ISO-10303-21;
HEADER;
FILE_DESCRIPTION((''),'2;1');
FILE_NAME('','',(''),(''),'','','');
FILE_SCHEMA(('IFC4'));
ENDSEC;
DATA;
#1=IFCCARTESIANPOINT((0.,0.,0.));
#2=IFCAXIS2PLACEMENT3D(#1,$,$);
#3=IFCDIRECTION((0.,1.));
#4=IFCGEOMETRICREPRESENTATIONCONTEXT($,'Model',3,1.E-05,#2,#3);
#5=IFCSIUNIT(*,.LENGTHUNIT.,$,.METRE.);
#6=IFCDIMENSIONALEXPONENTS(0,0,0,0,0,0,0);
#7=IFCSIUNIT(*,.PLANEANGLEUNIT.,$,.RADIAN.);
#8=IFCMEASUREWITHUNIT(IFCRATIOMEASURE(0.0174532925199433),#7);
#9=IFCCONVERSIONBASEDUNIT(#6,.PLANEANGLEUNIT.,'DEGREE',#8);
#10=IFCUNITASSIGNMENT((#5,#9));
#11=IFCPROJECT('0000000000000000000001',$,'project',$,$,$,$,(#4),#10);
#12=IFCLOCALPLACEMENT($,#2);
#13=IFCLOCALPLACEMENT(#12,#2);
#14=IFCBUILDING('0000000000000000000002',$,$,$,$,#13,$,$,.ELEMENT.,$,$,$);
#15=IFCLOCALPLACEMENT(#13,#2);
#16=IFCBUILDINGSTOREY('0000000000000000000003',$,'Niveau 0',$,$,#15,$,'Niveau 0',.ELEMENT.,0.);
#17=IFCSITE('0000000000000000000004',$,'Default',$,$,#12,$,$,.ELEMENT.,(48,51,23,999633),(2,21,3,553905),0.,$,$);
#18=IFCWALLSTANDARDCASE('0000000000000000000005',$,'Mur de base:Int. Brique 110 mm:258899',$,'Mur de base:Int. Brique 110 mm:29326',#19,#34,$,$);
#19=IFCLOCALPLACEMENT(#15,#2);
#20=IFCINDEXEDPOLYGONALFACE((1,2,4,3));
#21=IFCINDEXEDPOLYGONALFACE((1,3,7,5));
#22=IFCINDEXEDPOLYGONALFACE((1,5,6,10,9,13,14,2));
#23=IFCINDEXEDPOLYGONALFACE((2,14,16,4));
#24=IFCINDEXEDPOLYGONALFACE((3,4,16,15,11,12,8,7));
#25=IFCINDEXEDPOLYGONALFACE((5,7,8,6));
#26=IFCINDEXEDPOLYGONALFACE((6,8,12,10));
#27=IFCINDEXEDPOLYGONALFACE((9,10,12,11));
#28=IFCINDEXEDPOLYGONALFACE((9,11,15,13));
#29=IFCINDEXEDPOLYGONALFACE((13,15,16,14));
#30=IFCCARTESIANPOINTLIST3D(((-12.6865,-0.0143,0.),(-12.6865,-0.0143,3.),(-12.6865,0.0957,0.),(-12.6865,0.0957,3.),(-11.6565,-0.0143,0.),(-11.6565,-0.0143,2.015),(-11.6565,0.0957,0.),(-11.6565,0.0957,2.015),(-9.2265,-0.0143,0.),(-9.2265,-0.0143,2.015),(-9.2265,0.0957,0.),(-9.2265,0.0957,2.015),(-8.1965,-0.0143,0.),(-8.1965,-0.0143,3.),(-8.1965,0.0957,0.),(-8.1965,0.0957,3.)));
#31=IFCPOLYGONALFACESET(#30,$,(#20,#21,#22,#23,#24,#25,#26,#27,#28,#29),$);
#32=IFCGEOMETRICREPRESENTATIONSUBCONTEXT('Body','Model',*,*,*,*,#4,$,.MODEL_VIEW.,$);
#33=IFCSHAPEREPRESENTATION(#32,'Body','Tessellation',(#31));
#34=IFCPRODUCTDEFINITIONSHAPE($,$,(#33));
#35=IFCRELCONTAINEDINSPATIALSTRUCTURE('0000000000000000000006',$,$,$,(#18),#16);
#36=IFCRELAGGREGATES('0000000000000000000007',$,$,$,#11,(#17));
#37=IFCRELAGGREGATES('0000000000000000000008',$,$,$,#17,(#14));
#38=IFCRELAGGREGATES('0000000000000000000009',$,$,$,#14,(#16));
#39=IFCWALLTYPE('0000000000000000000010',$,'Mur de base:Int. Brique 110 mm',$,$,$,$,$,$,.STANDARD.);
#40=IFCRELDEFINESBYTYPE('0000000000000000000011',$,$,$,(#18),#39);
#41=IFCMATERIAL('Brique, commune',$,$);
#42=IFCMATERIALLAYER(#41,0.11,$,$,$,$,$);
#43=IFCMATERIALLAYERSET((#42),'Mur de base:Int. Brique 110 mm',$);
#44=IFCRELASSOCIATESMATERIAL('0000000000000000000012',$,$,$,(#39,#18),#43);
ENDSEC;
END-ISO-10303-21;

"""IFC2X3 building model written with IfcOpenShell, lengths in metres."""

from ifc_helpers import new_model, entity, si_unit, converted_unit, direction, frame, frame_2d, origin, origin_2d_with_axis, place, context, subcontext, project, spatial, rectangle, extrude, clip, halfspace, material, layer, layer_set, layer_usage, type_object, element, save


model = new_model("IFC2X3")

# Units and contexts
model_context = context("Model", 3, precision=1e-05, world=origin(), true_north=direction((0.0, 1.0)))
body_context = subcontext(model_context, "Body", "Model", "MODEL_VIEW")
ifc_project = project(units=[si_unit("LENGTHUNIT", "METRE"), converted_unit("PLANEANGLEUNIT", "DEGREE", entity("IfcRatioMeasure", 0.0174532925199433), si_unit("PLANEANGLEUNIT", "RADIAN"), dimensions=[0, 0, 0, 0, 0, 0, 0])], contexts=[model_context])

# Site, building, storey
site_placement = place(None, origin())
site = spatial("IfcSite", under=ifc_project, at=site_placement, Name="Default", CompositionType="ELEMENT", RefLatitude=(48, 51, 23, 999633), RefLongitude=(2, 21, 3, 553905), RefElevation=0.0)
building_placement = place(site_placement, origin())
building = spatial("IfcBuilding", under=site, at=building_placement, CompositionType="ELEMENT")
storey_placement = place(building_placement, origin())
storey = spatial("IfcBuildingStorey", under=building, at=storey_placement, Name="Niveau 0", LongName="Niveau 0", CompositionType="ELEMENT", Elevation=0.0)

# Shared definitions
ifc_material_1 = material(Name="Brique, commune")

# Shared definitions
ifc_layer_1 = layer(ifc_material_1, 0.11)
ifc_layer_set_1 = layer_set([ifc_layer_1], Name="Mur de base:Int. Brique 110 mm")
wall_type_1 = type_object("IfcWallType", Name="Mur de base:Int. Brique 110 mm", PredefinedType="STANDARD", material=ifc_layer_set_1)

# Wall, opening
ifc_layer_usage_1 = layer_usage(ifc_layer_set_1, "AXIS2", "NEGATIVE", 0.055)
wall_1_placement = place(storey_placement, frame((-12.6865, 0.0407, 0.0)))
wall_1 = element("IfcWallStandardCase", 1, at=wall_1_placement, inside=storey, type_object=wall_type_1, material=ifc_layer_usage_1, Name="Mur de base:Int. Brique 110 mm:258899", ObjectType="Mur de base:Int. Brique 110 mm:29326", context=body_context, shape_type="Clipping", body=[
    clip(extrude(rectangle(XDim=4.49, YDim=0.11, at=frame_2d((2.245, 0.0), x_axis=(-1.0, 0.0))), origin(), (0.0, 0.0, 1.0), 3.0), halfspace(origin(), True)),
])
opening_1_placement = place(wall_1_placement, frame((12.6865, -0.0407, 0.0)))
element("IfcOpeningElement", 2, at=opening_1_placement, cuts=wall_1, ObjectType="Opening", context=body_context, shape_type="SweptSolid", body=[
    extrude(rectangle(XDim=2.015, YDim=2.43, at=origin_2d_with_axis()), frame((-10.4415, -0.3143, 1.0075), z_axis=(0.0, 1.0, 0.0), x_axis=(0.0, 0.0, -1.0)), (0.0, 0.0, 1.0), 0.71),
])

save(model, "model.ifc")
